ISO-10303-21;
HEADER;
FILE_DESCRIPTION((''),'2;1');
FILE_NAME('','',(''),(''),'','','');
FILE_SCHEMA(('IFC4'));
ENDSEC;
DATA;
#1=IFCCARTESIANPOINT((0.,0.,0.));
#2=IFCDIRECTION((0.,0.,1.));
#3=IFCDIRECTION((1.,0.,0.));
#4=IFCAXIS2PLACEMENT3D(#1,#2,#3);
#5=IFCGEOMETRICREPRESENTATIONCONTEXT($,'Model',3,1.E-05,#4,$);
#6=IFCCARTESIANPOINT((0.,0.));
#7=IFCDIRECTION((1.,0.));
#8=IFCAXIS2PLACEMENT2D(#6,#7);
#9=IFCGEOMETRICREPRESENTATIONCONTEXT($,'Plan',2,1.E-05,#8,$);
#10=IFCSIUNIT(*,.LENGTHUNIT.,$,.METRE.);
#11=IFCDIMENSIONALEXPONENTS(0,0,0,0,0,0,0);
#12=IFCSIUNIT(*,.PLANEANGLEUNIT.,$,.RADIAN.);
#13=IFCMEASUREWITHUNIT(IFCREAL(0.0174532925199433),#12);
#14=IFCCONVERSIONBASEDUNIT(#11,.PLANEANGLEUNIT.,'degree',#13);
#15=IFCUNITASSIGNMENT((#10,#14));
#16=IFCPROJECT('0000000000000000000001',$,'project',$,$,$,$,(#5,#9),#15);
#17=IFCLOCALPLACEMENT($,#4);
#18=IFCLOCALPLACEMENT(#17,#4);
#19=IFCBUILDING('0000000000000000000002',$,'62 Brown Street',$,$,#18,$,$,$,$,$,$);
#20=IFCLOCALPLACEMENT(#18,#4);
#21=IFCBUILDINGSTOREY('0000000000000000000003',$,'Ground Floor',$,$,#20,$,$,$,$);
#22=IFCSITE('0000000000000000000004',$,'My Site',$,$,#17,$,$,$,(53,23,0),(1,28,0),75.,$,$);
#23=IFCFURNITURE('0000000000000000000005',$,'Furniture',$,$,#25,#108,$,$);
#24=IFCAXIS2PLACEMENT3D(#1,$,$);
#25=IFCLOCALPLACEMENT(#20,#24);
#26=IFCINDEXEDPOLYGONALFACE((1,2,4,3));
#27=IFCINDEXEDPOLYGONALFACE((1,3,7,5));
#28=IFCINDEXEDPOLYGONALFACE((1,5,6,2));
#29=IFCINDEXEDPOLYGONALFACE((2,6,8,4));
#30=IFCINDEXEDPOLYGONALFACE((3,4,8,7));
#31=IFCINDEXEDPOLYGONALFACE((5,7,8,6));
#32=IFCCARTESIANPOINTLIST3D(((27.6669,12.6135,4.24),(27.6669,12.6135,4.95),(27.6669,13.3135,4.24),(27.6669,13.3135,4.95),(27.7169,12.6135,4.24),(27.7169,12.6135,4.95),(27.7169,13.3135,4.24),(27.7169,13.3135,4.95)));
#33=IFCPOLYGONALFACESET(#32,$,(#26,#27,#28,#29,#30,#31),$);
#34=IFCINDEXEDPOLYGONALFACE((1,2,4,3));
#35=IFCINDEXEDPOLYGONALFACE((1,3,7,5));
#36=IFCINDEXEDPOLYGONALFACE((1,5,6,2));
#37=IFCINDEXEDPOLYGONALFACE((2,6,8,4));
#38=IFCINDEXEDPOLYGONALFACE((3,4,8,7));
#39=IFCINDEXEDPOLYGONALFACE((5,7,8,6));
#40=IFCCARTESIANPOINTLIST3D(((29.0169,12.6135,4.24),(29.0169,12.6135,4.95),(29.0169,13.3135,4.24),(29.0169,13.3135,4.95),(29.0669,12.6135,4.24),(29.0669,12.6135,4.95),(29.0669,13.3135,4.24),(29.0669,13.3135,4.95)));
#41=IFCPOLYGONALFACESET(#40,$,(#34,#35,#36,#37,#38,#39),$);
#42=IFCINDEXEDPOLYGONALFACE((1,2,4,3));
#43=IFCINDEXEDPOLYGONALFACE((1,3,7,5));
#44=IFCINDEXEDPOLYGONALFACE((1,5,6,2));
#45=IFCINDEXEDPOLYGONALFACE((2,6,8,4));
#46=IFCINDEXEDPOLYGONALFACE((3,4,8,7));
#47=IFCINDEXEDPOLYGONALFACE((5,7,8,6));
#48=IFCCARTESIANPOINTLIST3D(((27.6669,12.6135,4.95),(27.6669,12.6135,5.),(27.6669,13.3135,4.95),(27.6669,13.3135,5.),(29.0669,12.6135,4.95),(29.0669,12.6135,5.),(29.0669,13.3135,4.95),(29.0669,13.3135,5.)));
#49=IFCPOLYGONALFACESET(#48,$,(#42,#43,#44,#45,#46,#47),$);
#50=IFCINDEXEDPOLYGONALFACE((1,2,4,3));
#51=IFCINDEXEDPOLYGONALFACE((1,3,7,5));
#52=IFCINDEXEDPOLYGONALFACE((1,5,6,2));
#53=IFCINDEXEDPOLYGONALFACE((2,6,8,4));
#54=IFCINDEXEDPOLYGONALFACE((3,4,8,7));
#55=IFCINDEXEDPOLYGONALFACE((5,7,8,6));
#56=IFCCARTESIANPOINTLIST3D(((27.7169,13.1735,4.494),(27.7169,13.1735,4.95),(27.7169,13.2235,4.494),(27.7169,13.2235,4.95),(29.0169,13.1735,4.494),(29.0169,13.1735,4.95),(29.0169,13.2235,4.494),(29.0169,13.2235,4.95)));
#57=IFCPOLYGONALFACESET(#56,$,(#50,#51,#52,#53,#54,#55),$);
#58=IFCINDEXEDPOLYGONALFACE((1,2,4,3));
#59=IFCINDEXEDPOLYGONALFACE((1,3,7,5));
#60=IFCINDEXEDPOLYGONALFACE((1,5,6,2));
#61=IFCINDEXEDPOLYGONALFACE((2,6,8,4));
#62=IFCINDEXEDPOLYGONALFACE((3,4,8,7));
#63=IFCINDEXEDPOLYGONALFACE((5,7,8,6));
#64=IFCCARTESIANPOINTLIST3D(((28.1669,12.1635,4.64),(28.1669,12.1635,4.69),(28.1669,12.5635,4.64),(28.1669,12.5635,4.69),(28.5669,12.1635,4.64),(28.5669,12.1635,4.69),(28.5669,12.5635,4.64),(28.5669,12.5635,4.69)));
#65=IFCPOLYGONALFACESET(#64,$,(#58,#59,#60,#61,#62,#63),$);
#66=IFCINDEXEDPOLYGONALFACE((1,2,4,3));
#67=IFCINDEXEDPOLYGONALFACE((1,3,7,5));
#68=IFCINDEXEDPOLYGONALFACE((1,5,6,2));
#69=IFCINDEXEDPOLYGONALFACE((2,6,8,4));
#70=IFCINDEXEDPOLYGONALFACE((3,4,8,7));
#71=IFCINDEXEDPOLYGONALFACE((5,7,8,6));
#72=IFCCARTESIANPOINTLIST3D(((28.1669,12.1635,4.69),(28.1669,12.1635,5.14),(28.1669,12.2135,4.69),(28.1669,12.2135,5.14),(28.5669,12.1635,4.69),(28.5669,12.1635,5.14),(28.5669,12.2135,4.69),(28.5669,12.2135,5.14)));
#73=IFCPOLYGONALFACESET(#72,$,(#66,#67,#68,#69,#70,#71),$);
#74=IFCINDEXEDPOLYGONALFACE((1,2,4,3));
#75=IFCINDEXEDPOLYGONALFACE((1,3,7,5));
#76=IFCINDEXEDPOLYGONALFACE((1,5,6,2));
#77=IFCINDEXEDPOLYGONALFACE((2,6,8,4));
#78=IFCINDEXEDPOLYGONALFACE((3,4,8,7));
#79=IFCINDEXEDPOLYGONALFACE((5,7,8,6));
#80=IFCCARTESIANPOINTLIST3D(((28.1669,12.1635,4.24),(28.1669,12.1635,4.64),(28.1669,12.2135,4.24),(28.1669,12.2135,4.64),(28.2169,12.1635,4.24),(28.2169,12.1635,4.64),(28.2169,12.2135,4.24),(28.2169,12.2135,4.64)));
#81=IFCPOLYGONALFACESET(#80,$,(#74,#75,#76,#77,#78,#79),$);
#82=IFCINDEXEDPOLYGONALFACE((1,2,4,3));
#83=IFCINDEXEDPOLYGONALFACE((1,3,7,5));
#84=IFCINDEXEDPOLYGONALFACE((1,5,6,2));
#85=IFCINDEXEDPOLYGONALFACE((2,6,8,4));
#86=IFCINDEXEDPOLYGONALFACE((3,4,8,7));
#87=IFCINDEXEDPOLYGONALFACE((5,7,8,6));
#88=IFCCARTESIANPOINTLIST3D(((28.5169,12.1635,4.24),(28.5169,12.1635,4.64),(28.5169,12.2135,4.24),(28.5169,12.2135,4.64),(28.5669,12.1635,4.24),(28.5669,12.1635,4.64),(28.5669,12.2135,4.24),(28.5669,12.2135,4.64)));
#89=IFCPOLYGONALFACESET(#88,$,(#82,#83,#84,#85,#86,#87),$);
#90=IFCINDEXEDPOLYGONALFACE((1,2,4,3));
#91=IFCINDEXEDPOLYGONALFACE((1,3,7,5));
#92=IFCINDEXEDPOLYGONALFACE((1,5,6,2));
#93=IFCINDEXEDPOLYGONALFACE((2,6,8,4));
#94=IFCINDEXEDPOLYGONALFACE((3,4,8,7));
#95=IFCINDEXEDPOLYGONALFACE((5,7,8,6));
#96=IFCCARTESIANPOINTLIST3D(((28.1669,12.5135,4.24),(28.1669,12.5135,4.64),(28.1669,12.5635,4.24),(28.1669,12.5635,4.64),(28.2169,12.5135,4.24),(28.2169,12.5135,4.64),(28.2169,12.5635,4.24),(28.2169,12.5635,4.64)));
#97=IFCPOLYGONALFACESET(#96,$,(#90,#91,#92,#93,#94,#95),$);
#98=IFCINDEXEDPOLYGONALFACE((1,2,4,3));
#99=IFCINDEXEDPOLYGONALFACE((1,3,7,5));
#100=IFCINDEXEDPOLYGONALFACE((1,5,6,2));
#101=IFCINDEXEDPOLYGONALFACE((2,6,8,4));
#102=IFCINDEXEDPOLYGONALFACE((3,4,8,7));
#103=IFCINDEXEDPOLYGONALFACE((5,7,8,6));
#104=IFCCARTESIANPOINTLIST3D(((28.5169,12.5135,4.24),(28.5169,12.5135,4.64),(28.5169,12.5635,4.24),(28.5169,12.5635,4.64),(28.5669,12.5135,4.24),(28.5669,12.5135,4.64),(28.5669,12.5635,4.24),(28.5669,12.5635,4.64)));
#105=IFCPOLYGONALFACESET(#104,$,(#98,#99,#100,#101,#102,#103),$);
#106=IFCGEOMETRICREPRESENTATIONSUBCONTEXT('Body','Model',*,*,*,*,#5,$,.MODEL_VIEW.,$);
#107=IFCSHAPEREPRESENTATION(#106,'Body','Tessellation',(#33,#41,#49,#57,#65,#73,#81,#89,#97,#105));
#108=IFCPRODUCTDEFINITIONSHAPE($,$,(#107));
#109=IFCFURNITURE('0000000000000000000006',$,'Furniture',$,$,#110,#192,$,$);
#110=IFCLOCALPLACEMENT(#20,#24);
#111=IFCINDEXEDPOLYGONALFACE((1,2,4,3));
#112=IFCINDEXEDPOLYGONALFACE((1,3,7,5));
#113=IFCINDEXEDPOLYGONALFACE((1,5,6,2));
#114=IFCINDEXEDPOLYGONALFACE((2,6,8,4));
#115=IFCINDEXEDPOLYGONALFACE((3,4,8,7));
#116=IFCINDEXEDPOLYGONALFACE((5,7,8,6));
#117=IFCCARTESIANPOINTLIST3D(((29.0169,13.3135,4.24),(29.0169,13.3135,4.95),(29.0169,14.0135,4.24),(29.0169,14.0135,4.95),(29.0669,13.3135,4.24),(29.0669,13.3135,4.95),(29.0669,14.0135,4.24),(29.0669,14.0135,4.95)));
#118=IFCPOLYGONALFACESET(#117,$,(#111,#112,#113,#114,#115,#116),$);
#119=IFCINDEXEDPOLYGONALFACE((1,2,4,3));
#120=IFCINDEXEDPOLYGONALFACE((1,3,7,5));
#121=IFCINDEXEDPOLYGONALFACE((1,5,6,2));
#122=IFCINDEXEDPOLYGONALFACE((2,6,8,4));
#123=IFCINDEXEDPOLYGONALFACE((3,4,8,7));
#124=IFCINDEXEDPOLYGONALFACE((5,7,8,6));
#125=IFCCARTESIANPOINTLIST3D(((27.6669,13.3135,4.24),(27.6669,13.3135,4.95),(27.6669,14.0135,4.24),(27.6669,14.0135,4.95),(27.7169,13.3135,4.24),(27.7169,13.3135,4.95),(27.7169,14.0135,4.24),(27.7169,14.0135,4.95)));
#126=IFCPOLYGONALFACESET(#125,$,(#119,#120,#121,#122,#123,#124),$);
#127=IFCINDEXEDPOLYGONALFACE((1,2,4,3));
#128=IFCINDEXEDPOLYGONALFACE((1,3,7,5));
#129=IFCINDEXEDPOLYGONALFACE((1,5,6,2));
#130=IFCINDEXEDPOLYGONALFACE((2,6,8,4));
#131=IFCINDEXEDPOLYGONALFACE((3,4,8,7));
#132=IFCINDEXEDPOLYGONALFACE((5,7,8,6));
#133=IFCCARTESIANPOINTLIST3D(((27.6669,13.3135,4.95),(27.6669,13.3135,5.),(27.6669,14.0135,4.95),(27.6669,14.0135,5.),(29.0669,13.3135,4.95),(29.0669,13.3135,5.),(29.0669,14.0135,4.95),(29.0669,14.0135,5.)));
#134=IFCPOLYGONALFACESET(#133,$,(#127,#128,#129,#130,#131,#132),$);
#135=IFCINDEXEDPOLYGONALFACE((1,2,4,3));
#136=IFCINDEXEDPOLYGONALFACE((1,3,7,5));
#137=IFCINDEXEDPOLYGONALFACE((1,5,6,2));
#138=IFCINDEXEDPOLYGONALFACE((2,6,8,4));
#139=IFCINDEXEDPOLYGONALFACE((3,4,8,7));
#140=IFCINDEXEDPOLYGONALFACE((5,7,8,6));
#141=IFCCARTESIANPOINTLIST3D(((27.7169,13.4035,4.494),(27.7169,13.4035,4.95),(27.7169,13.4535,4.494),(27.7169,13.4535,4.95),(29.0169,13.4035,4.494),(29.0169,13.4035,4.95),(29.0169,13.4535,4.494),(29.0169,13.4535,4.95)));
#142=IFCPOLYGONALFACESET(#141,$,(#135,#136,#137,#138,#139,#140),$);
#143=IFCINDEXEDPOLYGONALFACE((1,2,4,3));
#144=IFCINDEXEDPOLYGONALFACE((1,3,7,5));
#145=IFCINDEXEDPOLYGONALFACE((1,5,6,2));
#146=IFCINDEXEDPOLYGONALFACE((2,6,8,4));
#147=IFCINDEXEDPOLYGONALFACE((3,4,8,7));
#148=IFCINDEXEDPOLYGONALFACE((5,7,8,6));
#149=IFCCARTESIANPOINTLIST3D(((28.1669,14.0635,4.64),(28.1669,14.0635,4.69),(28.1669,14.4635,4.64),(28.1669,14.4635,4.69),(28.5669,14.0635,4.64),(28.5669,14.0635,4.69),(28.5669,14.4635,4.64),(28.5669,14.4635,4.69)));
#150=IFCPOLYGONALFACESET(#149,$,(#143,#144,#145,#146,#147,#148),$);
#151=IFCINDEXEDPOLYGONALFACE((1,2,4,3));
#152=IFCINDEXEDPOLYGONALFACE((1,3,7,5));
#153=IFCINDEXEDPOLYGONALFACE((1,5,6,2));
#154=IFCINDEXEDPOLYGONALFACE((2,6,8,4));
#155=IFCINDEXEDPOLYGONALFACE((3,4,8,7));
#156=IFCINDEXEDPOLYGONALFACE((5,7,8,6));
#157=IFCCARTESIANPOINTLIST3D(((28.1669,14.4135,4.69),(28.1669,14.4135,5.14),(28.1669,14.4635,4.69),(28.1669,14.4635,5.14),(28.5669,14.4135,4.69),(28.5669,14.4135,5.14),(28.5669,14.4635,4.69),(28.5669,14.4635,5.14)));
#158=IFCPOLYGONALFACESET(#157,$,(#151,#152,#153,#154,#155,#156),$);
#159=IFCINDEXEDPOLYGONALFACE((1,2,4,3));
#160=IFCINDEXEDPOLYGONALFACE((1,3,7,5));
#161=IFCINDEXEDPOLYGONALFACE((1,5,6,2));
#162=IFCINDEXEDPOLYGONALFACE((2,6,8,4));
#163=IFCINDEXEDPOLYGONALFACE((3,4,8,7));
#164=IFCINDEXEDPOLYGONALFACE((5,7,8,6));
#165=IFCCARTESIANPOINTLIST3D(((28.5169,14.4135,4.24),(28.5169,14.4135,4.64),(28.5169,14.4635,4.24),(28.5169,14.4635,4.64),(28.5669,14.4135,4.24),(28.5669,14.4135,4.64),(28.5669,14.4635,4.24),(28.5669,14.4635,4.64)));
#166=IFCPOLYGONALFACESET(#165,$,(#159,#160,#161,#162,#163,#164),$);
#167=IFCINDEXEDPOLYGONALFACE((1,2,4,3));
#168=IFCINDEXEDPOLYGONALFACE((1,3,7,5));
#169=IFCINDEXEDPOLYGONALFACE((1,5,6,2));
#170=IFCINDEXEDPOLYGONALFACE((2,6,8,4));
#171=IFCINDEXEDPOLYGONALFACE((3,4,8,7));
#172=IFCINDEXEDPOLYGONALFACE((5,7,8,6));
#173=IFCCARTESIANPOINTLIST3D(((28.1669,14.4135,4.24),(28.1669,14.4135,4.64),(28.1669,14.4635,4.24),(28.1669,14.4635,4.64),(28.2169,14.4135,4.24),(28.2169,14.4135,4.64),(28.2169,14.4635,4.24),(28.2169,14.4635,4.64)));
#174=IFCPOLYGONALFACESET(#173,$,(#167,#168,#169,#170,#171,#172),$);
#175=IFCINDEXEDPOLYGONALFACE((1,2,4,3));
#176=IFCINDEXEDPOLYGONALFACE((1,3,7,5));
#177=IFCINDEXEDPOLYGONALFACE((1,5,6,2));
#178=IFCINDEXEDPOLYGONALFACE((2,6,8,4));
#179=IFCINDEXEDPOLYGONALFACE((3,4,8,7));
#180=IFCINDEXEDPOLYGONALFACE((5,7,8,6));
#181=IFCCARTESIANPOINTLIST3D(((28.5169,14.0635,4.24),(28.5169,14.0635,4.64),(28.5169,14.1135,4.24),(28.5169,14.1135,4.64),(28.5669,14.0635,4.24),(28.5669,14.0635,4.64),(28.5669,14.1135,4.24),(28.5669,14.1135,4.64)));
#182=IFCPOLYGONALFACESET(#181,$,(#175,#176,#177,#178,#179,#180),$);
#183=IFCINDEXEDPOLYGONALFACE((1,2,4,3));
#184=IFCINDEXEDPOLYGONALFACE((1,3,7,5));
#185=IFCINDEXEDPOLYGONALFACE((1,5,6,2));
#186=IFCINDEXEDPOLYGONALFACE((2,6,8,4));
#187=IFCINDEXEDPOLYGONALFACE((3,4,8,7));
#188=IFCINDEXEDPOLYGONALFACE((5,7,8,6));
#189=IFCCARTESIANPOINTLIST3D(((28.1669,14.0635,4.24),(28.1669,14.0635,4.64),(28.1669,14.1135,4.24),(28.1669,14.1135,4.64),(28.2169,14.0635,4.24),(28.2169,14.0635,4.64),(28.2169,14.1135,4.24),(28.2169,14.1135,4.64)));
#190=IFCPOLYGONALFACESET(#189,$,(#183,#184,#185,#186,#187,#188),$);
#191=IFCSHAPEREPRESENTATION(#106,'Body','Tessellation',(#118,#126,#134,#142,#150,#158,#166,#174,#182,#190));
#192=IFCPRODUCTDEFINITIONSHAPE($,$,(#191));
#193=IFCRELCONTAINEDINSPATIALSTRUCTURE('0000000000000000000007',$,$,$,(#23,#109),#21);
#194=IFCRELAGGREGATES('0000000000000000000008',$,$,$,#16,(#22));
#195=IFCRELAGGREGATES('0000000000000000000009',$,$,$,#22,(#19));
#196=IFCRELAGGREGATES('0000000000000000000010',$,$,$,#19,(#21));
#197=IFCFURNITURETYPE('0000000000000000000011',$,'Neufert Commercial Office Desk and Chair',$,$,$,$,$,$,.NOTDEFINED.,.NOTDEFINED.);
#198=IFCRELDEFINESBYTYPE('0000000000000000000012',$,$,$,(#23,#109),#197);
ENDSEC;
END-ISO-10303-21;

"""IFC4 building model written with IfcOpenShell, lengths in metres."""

from ifc_helpers import new_model, entity, si_unit, converted_unit, frame, origin_with_axes, origin_2d_with_axis, place, context, subcontext, project, spatial, line, indexed_curve, outline, extrude, shape, source, transform, mapped, type_object, type_shapes, element, save


model = new_model("IFC4")

# Units and contexts
model_context = context("Model", 3, precision=1e-05, world=origin_with_axes())
plan_context = context("Plan", 2, precision=1e-05, world=origin_2d_with_axis())
body_context_1 = subcontext(model_context, "Body", "Model", "MODEL_VIEW")
body_context_2 = subcontext(plan_context, "Body", "Plan", "PLAN_VIEW")
ifc_project = project(units=[si_unit("LENGTHUNIT", "METRE"), converted_unit("PLANEANGLEUNIT", "degree", entity("IfcReal", 0.0174532925199433), si_unit("PLANEANGLEUNIT", "RADIAN"), dimensions=[0, 0, 0, 0, 0, 0, 0])], contexts=[model_context, plan_context])

# Site, building, storey
site_placement = place(None, origin_with_axes())
site = spatial("IfcSite", under=ifc_project, at=site_placement, Name="My Site", RefLatitude=(53, 23, 0), RefLongitude=(1, 28, 0), RefElevation=75.0)
building_placement = place(site_placement, origin_with_axes())
building = spatial("IfcBuilding", under=site, at=building_placement, Name="62 Brown Street")
storey_placement = place(building_placement, origin_with_axes())
storey = spatial("IfcBuildingStorey", under=building, at=storey_placement, Name="Ground Floor")

# Furniture
furniture_type_1 = type_object("IfcFurnitureType", Name="Neufert Commercial Office Desk and Chair", AssemblyPlace="NOTDEFINED", PredefinedType="NOTDEFINED")
shared_shape_1 = source(origin_with_axes(), body_context_1, "Body", "SweptSolid", [
    extrude(outline(indexed_curve([(0.0, 0.0), (0.05, 0.0), (0.05, 0.7), (0.0, 0.7)], segments=[line(1, 2, 3, 4, 1)])), frame((0.0, 0.45, 0.0), z_axis=(0.0, 0.0, 1.0), x_axis=(1.0, 0.0, 0.0)), (0.0, 0.0, 1.0), 0.71),
    extrude(outline(indexed_curve([(0.0, 0.0), (0.05, 0.0), (0.05, 0.7), (0.0, 0.7)], segments=[line(1, 2, 3, 4, 1)])), frame((1.35, 0.45, 0.0), z_axis=(0.0, 0.0, 1.0), x_axis=(1.0, 0.0, 0.0)), (0.0, 0.0, 1.0), 0.71),
    extrude(outline(indexed_curve([(0.0, 0.0), (1.4, 0.0), (1.4, 0.7), (0.0, 0.7)], segments=[line(1, 2, 3, 4, 1)])), frame((0.0, 0.45, 0.71), z_axis=(0.0, 0.0, 1.0), x_axis=(1.0, 0.0, 0.0)), (0.0, 0.0, 1.0), 0.05),
    extrude(outline(indexed_curve([(0.05, 0.56), (1.35, 0.56), (1.35, 0.61), (0.05, 0.61)], segments=[line(1, 2, 3, 4, 1)])), frame((0.0, 0.45, 0.254), z_axis=(0.0, 0.0, 1.0), x_axis=(1.0, 0.0, 0.0)), (0.0, 0.0, 1.0), 0.456),
    extrude(outline(indexed_curve([(-0.2, 0.0), (0.2, 0.0), (0.2, 0.4), (-0.2, 0.4)], segments=[line(1, 2, 3, 4, 1)])), frame((0.7, 0.0, 0.45), z_axis=(0.0, 0.0, 1.0), x_axis=(1.0, 0.0, 0.0)), (0.0, 0.0, -1.0), 0.05),
    extrude(outline(indexed_curve([(-0.2, 0.0), (0.2, 0.0), (0.2, 0.05), (-0.2, 0.05)], segments=[line(1, 2, 3, 4, 1)])), frame((0.7, 0.0, 0.9), z_axis=(0.0, 0.0, 1.0), x_axis=(1.0, 0.0, 0.0)), (0.0, 0.0, -1.0), 0.45),
    extrude(outline(indexed_curve([(-0.2, 0.0), (-0.15, 0.0), (-0.15, 0.05), (-0.2, 0.05)], segments=[line(1, 2, 3, 4, 1)])), frame((0.7, 0.0, 0.0), z_axis=(0.0, 0.0, 1.0), x_axis=(1.0, 0.0, 0.0)), (0.0, 0.0, 1.0), 0.4),
    extrude(outline(indexed_curve([(0.2, 0.0), (0.15, 0.0), (0.15, 0.05), (0.2, 0.05)], segments=[line(1, 2, 3, 4, 1)])), frame((0.7, 0.0, 0.0), z_axis=(0.0, 0.0, 1.0), x_axis=(1.0, 0.0, 0.0)), (0.0, 0.0, 1.0), 0.4),
    extrude(outline(indexed_curve([(-0.2, 0.4), (-0.15, 0.4), (-0.15, 0.35), (-0.2, 0.35)], segments=[line(1, 2, 3, 4, 1)])), frame((0.7, 0.0, 0.0), z_axis=(0.0, 0.0, 1.0), x_axis=(1.0, 0.0, 0.0)), (0.0, 0.0, 1.0), 0.4),
    extrude(outline(indexed_curve([(0.2, 0.4), (0.15, 0.4), (0.15, 0.35), (0.2, 0.35)], segments=[line(1, 2, 3, 4, 1)])), frame((0.7, 0.0, 0.0), z_axis=(0.0, 0.0, 1.0), x_axis=(1.0, 0.0, 0.0)), (0.0, 0.0, 1.0), 0.4),
])
shared_shape_2 = source(origin_with_axes(), body_context_2, "Body", "Curve2D", [
    entity("IfcIndexedPolyCurve", entity("IfcCartesianPointList2D", [[0.0, 0.45], [1.4, 0.45], [1.4, 1.15], [0.0, 1.15]]), [entity("IfcLineIndex", [1, 2, 3, 4, 1])]),
    entity("IfcIndexedPolyCurve", entity("IfcCartesianPointList2D", [[0.5, 0.4], [0.9, 0.4]])),
    entity("IfcIndexedPolyCurve", entity("IfcCartesianPointList2D", [[0.5, 0.4], [0.5, 0.2], [0.5586, 0.0586], [0.7, 0.0], [0.8414, 0.0586], [0.9, 0.2], [0.9, 0.4]]), [entity("IfcLineIndex", [1, 2]), entity("IfcArcIndex", [2, 3, 4]), entity("IfcArcIndex", [4, 5, 6]), entity("IfcLineIndex", [6, 7])]),
    entity("IfcIndexedPolyCurve", entity("IfcCartesianPointList2D", [[0.54, 0.4], [0.54, 0.2], [0.5869, 0.0869], [0.7, 0.04], [0.8131, 0.0869], [0.86, 0.2], [0.86, 0.4]]), [entity("IfcLineIndex", [1, 2]), entity("IfcArcIndex", [2, 3, 4]), entity("IfcArcIndex", [4, 5, 6]), entity("IfcLineIndex", [6, 7])]),
])
type_shapes(furniture_type_1, [shared_shape_1, shared_shape_2])
for number, where, z_axis, x_axis, name in (
    (1, (27.6669, 12.1635, 4.24), (0.0, 0.0, 1.0), (1.0, 0.0, 0.0), "Furniture"),
    (2, (29.0669, 14.4635, 4.24), (0.0, 0.0, 1.0), (-1.0, 0.0, 0.0), "Furniture"),
):
    element("IfcFurniture", number, at=place(storey_placement, frame(where, z_axis=z_axis, x_axis=x_axis)), inside=storey, type_object=furniture_type_1, Name=name, shapes=[
        shape(body_context_1, "Body", "MappedRepresentation", [mapped(shared_shape_1, transform((0.0, 0.0, 0.0), x_axis=(1.0, 0.0, 0.0), y_axis=(0.0, 1.0, 0.0), z_axis=(0.0, 0.0, 1.0), scale=1.0))]),
        shape(body_context_2, "Body", "MappedRepresentation", [mapped(shared_shape_2, transform((0.0, 0.0, 0.0), x_axis=(1.0, 0.0, 0.0), y_axis=(0.0, 1.0, 0.0), z_axis=(0.0, 0.0, 1.0), scale=1.0))]),
    ])

save(model, "model.ifc")
